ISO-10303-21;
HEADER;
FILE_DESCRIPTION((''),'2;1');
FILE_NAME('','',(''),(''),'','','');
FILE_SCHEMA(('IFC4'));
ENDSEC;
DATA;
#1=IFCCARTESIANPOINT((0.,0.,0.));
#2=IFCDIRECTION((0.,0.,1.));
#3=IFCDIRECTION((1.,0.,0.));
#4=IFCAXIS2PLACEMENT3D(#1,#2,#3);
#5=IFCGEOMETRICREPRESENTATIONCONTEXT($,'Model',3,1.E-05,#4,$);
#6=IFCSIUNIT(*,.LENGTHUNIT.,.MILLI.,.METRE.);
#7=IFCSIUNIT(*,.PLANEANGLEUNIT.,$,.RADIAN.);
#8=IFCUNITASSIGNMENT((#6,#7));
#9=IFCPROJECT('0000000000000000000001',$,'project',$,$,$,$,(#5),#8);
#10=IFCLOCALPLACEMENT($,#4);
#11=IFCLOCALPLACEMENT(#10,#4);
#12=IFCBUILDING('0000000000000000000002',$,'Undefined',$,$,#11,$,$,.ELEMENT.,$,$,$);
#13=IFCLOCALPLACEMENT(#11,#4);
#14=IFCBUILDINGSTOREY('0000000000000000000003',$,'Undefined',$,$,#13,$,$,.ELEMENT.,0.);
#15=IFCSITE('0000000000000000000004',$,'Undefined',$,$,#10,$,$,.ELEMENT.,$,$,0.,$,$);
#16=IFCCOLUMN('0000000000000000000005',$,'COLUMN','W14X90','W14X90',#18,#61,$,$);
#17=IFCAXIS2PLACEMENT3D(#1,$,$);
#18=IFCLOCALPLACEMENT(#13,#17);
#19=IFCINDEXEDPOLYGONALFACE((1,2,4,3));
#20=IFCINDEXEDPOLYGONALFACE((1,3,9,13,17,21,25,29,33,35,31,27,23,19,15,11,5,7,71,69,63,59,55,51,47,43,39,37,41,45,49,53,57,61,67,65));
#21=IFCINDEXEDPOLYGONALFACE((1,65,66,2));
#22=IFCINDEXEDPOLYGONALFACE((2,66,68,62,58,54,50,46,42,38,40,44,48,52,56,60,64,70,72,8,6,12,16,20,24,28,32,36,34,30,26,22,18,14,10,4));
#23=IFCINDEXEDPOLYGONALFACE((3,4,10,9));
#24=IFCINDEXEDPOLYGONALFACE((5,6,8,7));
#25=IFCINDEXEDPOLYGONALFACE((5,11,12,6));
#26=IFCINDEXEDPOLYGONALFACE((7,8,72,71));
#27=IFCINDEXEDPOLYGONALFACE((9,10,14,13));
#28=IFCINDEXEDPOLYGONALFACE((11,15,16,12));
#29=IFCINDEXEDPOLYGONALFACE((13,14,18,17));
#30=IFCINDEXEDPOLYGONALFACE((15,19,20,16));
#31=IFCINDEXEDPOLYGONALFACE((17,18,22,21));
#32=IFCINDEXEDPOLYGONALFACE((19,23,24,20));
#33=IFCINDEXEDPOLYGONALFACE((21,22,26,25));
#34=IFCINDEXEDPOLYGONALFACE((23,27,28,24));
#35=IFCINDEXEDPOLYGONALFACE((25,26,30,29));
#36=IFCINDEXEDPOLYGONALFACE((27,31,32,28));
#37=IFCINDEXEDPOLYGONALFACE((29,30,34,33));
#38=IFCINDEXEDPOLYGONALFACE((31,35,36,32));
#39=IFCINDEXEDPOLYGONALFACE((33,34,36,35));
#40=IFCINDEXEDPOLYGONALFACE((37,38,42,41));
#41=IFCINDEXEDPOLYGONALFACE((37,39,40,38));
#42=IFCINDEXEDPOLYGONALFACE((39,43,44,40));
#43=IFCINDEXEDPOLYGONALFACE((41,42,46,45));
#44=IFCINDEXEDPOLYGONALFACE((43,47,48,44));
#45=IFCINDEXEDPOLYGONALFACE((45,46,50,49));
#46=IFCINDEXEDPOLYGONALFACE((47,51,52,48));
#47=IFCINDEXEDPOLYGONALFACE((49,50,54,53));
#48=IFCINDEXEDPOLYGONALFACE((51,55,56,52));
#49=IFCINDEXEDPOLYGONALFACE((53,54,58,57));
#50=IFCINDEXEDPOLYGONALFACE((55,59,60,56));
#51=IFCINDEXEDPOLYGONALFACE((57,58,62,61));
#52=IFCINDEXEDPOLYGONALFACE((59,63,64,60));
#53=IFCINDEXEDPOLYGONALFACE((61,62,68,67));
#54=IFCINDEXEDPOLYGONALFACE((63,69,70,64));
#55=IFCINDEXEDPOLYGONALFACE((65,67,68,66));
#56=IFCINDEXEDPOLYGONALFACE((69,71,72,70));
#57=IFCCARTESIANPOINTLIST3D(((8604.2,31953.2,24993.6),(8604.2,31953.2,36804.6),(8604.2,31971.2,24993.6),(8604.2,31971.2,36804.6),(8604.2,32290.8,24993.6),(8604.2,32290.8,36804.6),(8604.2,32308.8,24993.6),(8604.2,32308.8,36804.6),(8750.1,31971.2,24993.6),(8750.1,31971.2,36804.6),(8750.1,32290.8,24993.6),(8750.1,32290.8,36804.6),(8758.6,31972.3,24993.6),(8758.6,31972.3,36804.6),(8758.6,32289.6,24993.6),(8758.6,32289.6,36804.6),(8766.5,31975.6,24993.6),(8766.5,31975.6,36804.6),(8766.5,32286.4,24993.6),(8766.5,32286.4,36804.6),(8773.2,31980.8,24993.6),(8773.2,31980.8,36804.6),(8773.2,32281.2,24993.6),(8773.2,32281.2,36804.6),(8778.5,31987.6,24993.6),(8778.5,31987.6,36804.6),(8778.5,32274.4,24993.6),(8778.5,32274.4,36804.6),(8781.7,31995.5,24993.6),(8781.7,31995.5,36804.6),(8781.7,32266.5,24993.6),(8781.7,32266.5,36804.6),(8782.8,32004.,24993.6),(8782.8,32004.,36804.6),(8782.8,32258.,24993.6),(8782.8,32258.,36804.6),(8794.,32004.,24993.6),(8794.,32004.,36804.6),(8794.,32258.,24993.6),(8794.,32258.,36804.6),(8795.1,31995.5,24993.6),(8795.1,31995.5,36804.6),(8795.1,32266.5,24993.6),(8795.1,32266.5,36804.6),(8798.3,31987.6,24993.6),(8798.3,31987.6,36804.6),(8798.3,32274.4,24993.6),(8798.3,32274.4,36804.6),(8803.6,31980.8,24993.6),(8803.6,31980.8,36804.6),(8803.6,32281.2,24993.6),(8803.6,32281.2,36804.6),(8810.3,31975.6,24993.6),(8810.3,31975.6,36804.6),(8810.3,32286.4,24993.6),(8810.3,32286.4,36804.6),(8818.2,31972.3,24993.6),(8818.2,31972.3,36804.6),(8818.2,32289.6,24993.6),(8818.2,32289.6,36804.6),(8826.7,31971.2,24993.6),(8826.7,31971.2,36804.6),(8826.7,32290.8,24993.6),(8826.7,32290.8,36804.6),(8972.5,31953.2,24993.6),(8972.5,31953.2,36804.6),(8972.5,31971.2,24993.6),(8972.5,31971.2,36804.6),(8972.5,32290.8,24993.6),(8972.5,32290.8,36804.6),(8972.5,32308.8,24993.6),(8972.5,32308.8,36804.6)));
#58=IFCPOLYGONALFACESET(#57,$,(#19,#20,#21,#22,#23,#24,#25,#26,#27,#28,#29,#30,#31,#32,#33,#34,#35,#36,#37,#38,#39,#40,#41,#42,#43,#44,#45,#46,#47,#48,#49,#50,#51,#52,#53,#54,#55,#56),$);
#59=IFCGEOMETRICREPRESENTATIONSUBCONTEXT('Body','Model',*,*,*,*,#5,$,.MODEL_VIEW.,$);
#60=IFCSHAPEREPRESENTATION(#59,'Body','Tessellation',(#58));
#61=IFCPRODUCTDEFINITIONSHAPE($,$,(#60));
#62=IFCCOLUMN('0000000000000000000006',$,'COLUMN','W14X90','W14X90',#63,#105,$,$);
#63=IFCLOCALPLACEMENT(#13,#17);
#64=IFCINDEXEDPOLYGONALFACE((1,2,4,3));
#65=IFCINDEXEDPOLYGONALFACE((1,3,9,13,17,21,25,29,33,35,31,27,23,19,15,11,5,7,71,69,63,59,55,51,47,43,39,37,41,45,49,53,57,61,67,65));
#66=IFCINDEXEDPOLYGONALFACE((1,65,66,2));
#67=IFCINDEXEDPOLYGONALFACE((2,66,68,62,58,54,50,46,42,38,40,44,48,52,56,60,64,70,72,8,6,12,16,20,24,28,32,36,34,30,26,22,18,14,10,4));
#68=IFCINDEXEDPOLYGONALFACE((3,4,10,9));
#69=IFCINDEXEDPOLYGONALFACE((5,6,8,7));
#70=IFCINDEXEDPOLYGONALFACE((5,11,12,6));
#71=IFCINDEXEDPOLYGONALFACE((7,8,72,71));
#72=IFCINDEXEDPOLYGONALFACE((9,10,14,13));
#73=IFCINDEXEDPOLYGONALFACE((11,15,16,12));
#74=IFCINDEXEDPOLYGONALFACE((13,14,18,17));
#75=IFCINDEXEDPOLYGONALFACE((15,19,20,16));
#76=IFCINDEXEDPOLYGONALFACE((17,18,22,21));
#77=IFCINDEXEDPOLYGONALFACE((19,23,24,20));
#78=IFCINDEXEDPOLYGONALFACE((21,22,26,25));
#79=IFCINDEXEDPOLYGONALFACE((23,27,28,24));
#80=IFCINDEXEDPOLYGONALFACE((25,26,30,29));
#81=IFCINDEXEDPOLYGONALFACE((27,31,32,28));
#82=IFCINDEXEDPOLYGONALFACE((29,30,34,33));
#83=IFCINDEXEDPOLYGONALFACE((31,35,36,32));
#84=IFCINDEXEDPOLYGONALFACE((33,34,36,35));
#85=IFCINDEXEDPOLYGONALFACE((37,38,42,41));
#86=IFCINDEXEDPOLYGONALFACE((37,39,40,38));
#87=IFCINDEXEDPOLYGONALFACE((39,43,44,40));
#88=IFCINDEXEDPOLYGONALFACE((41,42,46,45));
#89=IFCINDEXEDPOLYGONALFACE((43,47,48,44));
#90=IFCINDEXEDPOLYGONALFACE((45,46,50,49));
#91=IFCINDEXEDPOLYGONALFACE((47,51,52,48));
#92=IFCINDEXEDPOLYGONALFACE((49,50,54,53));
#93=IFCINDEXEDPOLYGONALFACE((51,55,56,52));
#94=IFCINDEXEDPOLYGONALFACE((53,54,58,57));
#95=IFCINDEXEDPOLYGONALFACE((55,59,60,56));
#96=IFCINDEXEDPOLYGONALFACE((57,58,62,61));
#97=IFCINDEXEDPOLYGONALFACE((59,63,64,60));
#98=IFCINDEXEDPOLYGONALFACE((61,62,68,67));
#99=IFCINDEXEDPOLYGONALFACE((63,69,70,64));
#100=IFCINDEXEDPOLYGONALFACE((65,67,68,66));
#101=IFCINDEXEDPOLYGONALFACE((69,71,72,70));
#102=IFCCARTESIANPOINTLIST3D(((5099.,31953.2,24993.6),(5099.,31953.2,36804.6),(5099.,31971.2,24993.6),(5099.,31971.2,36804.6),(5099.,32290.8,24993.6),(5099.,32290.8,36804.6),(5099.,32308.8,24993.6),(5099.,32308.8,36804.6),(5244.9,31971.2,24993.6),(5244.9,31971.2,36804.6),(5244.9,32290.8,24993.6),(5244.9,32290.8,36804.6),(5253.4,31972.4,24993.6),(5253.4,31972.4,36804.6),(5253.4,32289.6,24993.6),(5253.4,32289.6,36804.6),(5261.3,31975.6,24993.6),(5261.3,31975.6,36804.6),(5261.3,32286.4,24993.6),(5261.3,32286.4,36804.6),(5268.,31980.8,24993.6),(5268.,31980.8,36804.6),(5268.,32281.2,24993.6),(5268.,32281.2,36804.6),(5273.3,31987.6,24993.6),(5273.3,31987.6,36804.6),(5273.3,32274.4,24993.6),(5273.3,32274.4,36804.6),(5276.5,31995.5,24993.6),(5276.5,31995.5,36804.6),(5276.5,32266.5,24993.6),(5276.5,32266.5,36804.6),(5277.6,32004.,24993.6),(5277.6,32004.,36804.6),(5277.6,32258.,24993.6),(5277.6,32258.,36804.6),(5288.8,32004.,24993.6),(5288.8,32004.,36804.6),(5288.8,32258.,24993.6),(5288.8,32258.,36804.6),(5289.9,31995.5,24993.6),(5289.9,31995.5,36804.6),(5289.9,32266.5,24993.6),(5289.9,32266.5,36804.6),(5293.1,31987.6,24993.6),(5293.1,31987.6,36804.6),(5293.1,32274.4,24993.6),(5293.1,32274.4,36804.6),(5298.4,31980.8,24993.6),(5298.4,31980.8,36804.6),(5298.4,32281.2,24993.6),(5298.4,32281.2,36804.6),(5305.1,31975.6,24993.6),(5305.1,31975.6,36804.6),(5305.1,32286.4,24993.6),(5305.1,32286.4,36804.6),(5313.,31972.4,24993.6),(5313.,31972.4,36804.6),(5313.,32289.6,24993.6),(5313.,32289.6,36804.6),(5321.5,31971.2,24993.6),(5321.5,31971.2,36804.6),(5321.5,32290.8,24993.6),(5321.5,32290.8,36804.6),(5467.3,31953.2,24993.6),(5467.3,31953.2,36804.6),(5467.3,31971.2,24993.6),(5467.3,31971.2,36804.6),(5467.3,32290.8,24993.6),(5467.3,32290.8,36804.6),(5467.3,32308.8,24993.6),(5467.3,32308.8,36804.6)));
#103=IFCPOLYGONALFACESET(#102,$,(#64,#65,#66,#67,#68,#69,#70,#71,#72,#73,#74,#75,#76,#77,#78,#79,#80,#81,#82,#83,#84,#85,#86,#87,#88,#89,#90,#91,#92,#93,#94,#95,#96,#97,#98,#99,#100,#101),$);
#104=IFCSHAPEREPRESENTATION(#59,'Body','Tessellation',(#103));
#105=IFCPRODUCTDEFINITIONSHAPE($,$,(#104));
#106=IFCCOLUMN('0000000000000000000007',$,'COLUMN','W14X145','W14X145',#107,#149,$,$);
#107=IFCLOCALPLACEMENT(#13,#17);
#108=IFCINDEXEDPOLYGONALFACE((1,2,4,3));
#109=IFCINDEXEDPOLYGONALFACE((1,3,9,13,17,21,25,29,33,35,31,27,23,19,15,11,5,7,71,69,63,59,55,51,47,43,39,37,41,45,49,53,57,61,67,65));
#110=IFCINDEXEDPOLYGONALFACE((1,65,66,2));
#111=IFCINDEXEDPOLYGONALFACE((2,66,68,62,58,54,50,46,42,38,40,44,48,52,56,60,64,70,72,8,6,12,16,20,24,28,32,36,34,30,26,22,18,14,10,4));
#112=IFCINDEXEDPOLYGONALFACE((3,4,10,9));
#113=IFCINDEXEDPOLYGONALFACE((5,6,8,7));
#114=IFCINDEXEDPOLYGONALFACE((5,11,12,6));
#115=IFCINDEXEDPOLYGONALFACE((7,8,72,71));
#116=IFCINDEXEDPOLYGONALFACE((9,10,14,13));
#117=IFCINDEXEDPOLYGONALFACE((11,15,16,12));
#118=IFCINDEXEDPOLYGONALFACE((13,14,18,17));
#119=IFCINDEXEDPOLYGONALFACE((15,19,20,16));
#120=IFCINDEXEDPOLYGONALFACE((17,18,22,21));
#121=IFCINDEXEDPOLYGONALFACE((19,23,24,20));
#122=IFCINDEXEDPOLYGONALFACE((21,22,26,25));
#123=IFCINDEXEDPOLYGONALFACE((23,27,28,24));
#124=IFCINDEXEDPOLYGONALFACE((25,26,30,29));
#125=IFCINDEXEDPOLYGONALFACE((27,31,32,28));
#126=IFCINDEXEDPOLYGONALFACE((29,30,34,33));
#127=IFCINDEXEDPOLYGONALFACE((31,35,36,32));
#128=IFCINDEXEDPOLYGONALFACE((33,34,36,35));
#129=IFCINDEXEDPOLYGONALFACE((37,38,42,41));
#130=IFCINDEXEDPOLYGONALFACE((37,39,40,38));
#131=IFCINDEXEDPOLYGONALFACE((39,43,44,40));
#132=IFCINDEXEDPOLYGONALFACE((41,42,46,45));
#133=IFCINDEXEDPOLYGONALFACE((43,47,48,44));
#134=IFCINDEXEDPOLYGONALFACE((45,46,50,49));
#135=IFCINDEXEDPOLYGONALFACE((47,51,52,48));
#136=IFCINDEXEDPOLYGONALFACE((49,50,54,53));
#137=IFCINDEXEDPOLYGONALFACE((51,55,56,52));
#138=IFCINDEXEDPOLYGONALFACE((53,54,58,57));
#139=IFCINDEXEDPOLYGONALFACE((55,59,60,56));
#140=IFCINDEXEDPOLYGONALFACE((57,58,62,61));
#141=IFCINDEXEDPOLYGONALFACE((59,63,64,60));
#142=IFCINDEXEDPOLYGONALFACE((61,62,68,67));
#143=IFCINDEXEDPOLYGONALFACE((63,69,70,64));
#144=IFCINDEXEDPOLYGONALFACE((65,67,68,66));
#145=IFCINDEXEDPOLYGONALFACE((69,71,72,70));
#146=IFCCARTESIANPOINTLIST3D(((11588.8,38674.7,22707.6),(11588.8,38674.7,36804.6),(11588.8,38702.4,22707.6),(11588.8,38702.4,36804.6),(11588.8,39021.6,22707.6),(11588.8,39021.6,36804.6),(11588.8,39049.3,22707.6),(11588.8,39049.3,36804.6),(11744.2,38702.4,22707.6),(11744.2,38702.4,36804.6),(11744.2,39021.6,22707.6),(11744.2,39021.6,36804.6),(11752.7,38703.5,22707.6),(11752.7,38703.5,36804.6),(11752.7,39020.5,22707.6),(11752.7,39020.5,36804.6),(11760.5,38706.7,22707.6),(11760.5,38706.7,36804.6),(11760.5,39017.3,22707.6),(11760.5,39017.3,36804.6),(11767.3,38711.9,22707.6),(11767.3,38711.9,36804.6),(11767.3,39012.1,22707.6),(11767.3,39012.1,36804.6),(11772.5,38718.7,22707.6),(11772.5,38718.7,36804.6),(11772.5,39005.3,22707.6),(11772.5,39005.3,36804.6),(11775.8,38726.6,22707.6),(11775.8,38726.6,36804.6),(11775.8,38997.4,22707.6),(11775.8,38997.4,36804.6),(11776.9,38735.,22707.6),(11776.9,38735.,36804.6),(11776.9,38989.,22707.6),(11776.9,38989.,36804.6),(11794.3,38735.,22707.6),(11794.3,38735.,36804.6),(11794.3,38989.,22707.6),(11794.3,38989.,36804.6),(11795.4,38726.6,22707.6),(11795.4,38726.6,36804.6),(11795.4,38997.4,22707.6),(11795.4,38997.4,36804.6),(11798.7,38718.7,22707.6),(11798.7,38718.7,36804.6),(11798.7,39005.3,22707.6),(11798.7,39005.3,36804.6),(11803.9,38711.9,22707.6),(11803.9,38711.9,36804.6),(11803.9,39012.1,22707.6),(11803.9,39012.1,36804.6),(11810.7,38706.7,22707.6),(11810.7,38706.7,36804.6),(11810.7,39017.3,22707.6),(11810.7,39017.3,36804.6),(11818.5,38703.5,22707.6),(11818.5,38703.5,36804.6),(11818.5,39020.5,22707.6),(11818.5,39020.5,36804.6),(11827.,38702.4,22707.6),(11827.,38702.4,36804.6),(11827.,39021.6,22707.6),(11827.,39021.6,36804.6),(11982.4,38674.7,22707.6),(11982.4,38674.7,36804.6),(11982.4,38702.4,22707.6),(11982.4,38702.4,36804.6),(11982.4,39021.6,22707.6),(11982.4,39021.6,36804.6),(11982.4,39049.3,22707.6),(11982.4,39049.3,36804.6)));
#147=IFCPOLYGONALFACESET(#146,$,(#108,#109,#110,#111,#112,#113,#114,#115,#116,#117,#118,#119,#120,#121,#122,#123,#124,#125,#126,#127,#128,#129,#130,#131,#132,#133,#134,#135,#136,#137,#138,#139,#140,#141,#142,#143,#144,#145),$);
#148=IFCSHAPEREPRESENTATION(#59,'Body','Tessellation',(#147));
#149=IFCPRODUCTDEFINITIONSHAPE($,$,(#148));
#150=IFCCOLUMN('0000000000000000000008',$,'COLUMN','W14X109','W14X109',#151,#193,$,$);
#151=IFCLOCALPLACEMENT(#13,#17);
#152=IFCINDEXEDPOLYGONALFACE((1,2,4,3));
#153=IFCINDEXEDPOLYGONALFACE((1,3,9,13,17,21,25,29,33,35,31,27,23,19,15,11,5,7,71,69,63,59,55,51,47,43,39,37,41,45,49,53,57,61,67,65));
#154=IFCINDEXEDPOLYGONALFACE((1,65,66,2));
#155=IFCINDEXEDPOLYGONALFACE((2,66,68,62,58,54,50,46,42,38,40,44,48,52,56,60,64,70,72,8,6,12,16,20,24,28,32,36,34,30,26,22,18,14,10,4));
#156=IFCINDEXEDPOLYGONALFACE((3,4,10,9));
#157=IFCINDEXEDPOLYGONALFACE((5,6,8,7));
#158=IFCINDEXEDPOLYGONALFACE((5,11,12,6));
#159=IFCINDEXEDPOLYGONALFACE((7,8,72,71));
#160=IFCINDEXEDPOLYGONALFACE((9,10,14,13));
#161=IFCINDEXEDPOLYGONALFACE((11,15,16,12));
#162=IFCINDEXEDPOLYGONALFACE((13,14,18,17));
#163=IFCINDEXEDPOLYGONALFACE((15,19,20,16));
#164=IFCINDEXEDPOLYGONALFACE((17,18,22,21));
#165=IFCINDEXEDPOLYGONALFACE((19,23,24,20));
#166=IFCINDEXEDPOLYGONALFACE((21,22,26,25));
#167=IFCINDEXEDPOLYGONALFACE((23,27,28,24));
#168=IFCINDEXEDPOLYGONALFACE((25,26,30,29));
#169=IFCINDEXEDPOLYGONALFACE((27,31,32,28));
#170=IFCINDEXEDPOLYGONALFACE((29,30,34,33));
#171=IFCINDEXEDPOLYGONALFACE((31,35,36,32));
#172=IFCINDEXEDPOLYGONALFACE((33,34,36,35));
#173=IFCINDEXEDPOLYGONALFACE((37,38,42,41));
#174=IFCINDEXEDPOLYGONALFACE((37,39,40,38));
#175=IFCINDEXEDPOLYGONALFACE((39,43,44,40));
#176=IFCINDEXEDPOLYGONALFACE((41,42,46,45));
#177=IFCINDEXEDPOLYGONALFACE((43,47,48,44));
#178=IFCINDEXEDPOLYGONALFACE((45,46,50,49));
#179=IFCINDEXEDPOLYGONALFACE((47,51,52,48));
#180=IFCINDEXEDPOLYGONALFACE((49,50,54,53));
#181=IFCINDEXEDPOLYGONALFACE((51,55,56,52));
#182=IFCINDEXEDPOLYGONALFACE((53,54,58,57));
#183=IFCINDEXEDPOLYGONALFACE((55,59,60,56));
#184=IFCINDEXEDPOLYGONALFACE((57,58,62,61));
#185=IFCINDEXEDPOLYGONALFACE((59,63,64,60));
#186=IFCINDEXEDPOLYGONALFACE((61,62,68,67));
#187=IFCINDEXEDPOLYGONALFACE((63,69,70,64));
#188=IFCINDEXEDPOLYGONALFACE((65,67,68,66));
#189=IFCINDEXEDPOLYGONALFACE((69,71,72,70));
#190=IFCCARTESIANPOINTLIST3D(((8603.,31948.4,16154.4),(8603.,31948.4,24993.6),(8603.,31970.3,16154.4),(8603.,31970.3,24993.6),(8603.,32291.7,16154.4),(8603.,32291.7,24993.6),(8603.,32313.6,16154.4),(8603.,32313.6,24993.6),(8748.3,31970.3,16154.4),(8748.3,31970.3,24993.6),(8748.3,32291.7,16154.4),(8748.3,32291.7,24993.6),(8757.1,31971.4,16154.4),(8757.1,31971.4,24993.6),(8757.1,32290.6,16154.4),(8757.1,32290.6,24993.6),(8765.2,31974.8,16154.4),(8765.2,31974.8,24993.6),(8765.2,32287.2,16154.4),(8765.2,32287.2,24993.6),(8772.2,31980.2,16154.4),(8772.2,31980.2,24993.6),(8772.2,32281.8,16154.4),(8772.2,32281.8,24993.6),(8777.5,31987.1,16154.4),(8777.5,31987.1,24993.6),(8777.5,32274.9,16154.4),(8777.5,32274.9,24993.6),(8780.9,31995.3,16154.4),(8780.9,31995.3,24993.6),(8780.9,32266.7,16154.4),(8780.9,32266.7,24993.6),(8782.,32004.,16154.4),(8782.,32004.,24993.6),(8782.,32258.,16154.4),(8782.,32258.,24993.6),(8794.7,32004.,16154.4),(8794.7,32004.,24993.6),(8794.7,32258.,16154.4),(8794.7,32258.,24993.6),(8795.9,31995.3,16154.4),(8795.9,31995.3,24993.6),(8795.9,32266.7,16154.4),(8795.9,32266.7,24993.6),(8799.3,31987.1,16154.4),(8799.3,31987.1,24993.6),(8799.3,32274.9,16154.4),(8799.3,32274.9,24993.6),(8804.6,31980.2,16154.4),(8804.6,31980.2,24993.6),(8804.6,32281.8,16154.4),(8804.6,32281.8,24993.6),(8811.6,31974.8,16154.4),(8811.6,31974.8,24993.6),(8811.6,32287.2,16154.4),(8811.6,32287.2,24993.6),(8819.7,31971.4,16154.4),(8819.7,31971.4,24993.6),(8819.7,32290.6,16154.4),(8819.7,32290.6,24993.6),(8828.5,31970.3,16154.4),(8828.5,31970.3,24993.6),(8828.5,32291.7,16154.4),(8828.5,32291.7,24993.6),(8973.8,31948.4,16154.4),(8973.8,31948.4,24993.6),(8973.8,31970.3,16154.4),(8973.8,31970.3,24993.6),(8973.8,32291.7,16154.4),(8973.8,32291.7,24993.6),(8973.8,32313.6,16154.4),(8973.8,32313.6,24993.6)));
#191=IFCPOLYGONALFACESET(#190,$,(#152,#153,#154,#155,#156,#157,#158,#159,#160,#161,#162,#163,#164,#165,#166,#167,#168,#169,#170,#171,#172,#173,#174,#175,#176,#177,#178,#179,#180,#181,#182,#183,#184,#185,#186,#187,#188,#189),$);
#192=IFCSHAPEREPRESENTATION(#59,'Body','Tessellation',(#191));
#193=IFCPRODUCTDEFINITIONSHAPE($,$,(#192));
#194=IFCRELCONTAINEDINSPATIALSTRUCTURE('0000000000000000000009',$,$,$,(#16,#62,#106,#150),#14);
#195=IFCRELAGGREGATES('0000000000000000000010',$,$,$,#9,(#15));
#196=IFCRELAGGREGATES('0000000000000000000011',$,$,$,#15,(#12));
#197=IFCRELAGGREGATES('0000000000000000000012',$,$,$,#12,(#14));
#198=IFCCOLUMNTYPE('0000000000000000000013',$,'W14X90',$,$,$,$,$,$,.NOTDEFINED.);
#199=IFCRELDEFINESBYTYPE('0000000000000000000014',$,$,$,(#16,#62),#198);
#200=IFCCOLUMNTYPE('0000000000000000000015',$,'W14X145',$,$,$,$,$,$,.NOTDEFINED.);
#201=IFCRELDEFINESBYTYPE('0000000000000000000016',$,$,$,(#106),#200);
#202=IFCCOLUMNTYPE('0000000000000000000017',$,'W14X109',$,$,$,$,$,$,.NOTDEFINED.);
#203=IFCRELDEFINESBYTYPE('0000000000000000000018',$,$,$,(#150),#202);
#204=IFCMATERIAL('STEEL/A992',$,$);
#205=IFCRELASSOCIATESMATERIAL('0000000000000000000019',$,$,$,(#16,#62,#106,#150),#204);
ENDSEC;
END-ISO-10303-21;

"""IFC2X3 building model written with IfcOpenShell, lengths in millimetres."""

from ifc_helpers import new_model, si_unit, frame, origin_with_axes, origin_2d_with_axis, place, context, subcontext, project, spatial, i_section, extrude, material, type_object, element, save


model = new_model("IFC2X3")

# Units and contexts
model_context = context("Model", 3, precision=1e-05, world=origin_with_axes())
body_context = subcontext(model_context, "Body", "Model", "MODEL_VIEW")
ifc_project = project(units=[si_unit("LENGTHUNIT", "METRE", prefix="MILLI"), si_unit("PLANEANGLEUNIT", "RADIAN")], contexts=[model_context])

# Site, building, storey
site_placement = place(None, origin_with_axes())
site = spatial("IfcSite", under=ifc_project, at=site_placement, Name="Undefined", CompositionType="ELEMENT", RefElevation=0.0)
building_placement = place(site_placement, origin_with_axes())
building = spatial("IfcBuilding", under=site, at=building_placement, Name="Undefined", CompositionType="ELEMENT")
storey_placement = place(building_placement, origin_with_axes())
storey = spatial("IfcBuildingStorey", under=building, at=storey_placement, Name="Undefined", CompositionType="ELEMENT", Elevation=0.0)

# Columns
ifc_material_1 = material(Name="STEEL/A992")
column_type_1 = type_object("IfcColumnType", Name="W14X90", PredefinedType="NOTDEFINED")
for number, where, z_axis, x_axis, name in (
    (1, (8788.4, 32131.0, 24993.6), (0.0, 0.0, 1.0), (1.0, 0.0, 0.0), "COLUMN"),
    (2, (5283.2, 32131.0, 24993.6), (0.0, 0.0, 1.0), (1.0, 0.0, 0.0), "COLUMN"),
):
    element("IfcColumn", number, at=place(storey_placement, frame(where, z_axis=z_axis, x_axis=x_axis)), inside=storey, type_object=column_type_1, material=ifc_material_1, Name=name, Description="W14X90", ObjectType="W14X90", context=body_context, shape_type="SweptSolid", body=[
        extrude(i_section(OverallWidth=368.3, OverallDepth=355.6, WebThickness=11.1, FlangeThickness=18.0, FilletRadius=32.8, at=origin_2d_with_axis()), frame((0.0, 0.0, 11811.0), z_axis=(0.0, 0.0, -1.0), x_axis=(-1.0, 0.0, 0.0)), (0.0, 0.0, 1.0), 11811.0),
    ])
column_type_2 = type_object("IfcColumnType", Name="W14X145", PredefinedType="NOTDEFINED")
column_1_placement = place(storey_placement, frame((11785.6, 38862.0, 22707.6), z_axis=(0.0, 0.0, 1.0), x_axis=(1.0, 0.0, 0.0)))
element("IfcColumn", 3, at=column_1_placement, inside=storey, type_object=column_type_2, material=ifc_material_1, Name="COLUMN", Description="W14X145", ObjectType="W14X145", context=body_context, shape_type="SweptSolid", body=[
    extrude(i_section(OverallWidth=393.7, OverallDepth=374.6, WebThickness=17.5, FlangeThickness=27.7, FilletRadius=32.6, at=origin_2d_with_axis()), frame((0.0, 0.0, 14097.0), z_axis=(0.0, 0.0, -1.0), x_axis=(-1.0, 0.0, 0.0)), (0.0, 0.0, 1.0), 14097.0),
])
column_type_3 = type_object("IfcColumnType", Name="W14X109", PredefinedType="NOTDEFINED")
column_2_placement = place(storey_placement, frame((8788.4, 32131.0, 16154.4), z_axis=(0.0, 0.0, 1.0), x_axis=(1.0, 0.0, 0.0)))
element("IfcColumn", 4, at=column_2_placement, inside=storey, type_object=column_type_3, material=ifc_material_1, Name="COLUMN", Description="W14X109", ObjectType="W14X109", context=body_context, shape_type="SweptSolid", body=[
    extrude(i_section(OverallWidth=370.8, OverallDepth=365.1, WebThickness=12.7, FlangeThickness=21.8, FilletRadius=33.7, at=origin_2d_with_axis()), frame((0.0, 0.0, 8839.2), z_axis=(0.0, 0.0, -1.0), x_axis=(-1.0, 0.0, 0.0)), (0.0, 0.0, 1.0), 8839.2),
])

save(model, "model.ifc")
